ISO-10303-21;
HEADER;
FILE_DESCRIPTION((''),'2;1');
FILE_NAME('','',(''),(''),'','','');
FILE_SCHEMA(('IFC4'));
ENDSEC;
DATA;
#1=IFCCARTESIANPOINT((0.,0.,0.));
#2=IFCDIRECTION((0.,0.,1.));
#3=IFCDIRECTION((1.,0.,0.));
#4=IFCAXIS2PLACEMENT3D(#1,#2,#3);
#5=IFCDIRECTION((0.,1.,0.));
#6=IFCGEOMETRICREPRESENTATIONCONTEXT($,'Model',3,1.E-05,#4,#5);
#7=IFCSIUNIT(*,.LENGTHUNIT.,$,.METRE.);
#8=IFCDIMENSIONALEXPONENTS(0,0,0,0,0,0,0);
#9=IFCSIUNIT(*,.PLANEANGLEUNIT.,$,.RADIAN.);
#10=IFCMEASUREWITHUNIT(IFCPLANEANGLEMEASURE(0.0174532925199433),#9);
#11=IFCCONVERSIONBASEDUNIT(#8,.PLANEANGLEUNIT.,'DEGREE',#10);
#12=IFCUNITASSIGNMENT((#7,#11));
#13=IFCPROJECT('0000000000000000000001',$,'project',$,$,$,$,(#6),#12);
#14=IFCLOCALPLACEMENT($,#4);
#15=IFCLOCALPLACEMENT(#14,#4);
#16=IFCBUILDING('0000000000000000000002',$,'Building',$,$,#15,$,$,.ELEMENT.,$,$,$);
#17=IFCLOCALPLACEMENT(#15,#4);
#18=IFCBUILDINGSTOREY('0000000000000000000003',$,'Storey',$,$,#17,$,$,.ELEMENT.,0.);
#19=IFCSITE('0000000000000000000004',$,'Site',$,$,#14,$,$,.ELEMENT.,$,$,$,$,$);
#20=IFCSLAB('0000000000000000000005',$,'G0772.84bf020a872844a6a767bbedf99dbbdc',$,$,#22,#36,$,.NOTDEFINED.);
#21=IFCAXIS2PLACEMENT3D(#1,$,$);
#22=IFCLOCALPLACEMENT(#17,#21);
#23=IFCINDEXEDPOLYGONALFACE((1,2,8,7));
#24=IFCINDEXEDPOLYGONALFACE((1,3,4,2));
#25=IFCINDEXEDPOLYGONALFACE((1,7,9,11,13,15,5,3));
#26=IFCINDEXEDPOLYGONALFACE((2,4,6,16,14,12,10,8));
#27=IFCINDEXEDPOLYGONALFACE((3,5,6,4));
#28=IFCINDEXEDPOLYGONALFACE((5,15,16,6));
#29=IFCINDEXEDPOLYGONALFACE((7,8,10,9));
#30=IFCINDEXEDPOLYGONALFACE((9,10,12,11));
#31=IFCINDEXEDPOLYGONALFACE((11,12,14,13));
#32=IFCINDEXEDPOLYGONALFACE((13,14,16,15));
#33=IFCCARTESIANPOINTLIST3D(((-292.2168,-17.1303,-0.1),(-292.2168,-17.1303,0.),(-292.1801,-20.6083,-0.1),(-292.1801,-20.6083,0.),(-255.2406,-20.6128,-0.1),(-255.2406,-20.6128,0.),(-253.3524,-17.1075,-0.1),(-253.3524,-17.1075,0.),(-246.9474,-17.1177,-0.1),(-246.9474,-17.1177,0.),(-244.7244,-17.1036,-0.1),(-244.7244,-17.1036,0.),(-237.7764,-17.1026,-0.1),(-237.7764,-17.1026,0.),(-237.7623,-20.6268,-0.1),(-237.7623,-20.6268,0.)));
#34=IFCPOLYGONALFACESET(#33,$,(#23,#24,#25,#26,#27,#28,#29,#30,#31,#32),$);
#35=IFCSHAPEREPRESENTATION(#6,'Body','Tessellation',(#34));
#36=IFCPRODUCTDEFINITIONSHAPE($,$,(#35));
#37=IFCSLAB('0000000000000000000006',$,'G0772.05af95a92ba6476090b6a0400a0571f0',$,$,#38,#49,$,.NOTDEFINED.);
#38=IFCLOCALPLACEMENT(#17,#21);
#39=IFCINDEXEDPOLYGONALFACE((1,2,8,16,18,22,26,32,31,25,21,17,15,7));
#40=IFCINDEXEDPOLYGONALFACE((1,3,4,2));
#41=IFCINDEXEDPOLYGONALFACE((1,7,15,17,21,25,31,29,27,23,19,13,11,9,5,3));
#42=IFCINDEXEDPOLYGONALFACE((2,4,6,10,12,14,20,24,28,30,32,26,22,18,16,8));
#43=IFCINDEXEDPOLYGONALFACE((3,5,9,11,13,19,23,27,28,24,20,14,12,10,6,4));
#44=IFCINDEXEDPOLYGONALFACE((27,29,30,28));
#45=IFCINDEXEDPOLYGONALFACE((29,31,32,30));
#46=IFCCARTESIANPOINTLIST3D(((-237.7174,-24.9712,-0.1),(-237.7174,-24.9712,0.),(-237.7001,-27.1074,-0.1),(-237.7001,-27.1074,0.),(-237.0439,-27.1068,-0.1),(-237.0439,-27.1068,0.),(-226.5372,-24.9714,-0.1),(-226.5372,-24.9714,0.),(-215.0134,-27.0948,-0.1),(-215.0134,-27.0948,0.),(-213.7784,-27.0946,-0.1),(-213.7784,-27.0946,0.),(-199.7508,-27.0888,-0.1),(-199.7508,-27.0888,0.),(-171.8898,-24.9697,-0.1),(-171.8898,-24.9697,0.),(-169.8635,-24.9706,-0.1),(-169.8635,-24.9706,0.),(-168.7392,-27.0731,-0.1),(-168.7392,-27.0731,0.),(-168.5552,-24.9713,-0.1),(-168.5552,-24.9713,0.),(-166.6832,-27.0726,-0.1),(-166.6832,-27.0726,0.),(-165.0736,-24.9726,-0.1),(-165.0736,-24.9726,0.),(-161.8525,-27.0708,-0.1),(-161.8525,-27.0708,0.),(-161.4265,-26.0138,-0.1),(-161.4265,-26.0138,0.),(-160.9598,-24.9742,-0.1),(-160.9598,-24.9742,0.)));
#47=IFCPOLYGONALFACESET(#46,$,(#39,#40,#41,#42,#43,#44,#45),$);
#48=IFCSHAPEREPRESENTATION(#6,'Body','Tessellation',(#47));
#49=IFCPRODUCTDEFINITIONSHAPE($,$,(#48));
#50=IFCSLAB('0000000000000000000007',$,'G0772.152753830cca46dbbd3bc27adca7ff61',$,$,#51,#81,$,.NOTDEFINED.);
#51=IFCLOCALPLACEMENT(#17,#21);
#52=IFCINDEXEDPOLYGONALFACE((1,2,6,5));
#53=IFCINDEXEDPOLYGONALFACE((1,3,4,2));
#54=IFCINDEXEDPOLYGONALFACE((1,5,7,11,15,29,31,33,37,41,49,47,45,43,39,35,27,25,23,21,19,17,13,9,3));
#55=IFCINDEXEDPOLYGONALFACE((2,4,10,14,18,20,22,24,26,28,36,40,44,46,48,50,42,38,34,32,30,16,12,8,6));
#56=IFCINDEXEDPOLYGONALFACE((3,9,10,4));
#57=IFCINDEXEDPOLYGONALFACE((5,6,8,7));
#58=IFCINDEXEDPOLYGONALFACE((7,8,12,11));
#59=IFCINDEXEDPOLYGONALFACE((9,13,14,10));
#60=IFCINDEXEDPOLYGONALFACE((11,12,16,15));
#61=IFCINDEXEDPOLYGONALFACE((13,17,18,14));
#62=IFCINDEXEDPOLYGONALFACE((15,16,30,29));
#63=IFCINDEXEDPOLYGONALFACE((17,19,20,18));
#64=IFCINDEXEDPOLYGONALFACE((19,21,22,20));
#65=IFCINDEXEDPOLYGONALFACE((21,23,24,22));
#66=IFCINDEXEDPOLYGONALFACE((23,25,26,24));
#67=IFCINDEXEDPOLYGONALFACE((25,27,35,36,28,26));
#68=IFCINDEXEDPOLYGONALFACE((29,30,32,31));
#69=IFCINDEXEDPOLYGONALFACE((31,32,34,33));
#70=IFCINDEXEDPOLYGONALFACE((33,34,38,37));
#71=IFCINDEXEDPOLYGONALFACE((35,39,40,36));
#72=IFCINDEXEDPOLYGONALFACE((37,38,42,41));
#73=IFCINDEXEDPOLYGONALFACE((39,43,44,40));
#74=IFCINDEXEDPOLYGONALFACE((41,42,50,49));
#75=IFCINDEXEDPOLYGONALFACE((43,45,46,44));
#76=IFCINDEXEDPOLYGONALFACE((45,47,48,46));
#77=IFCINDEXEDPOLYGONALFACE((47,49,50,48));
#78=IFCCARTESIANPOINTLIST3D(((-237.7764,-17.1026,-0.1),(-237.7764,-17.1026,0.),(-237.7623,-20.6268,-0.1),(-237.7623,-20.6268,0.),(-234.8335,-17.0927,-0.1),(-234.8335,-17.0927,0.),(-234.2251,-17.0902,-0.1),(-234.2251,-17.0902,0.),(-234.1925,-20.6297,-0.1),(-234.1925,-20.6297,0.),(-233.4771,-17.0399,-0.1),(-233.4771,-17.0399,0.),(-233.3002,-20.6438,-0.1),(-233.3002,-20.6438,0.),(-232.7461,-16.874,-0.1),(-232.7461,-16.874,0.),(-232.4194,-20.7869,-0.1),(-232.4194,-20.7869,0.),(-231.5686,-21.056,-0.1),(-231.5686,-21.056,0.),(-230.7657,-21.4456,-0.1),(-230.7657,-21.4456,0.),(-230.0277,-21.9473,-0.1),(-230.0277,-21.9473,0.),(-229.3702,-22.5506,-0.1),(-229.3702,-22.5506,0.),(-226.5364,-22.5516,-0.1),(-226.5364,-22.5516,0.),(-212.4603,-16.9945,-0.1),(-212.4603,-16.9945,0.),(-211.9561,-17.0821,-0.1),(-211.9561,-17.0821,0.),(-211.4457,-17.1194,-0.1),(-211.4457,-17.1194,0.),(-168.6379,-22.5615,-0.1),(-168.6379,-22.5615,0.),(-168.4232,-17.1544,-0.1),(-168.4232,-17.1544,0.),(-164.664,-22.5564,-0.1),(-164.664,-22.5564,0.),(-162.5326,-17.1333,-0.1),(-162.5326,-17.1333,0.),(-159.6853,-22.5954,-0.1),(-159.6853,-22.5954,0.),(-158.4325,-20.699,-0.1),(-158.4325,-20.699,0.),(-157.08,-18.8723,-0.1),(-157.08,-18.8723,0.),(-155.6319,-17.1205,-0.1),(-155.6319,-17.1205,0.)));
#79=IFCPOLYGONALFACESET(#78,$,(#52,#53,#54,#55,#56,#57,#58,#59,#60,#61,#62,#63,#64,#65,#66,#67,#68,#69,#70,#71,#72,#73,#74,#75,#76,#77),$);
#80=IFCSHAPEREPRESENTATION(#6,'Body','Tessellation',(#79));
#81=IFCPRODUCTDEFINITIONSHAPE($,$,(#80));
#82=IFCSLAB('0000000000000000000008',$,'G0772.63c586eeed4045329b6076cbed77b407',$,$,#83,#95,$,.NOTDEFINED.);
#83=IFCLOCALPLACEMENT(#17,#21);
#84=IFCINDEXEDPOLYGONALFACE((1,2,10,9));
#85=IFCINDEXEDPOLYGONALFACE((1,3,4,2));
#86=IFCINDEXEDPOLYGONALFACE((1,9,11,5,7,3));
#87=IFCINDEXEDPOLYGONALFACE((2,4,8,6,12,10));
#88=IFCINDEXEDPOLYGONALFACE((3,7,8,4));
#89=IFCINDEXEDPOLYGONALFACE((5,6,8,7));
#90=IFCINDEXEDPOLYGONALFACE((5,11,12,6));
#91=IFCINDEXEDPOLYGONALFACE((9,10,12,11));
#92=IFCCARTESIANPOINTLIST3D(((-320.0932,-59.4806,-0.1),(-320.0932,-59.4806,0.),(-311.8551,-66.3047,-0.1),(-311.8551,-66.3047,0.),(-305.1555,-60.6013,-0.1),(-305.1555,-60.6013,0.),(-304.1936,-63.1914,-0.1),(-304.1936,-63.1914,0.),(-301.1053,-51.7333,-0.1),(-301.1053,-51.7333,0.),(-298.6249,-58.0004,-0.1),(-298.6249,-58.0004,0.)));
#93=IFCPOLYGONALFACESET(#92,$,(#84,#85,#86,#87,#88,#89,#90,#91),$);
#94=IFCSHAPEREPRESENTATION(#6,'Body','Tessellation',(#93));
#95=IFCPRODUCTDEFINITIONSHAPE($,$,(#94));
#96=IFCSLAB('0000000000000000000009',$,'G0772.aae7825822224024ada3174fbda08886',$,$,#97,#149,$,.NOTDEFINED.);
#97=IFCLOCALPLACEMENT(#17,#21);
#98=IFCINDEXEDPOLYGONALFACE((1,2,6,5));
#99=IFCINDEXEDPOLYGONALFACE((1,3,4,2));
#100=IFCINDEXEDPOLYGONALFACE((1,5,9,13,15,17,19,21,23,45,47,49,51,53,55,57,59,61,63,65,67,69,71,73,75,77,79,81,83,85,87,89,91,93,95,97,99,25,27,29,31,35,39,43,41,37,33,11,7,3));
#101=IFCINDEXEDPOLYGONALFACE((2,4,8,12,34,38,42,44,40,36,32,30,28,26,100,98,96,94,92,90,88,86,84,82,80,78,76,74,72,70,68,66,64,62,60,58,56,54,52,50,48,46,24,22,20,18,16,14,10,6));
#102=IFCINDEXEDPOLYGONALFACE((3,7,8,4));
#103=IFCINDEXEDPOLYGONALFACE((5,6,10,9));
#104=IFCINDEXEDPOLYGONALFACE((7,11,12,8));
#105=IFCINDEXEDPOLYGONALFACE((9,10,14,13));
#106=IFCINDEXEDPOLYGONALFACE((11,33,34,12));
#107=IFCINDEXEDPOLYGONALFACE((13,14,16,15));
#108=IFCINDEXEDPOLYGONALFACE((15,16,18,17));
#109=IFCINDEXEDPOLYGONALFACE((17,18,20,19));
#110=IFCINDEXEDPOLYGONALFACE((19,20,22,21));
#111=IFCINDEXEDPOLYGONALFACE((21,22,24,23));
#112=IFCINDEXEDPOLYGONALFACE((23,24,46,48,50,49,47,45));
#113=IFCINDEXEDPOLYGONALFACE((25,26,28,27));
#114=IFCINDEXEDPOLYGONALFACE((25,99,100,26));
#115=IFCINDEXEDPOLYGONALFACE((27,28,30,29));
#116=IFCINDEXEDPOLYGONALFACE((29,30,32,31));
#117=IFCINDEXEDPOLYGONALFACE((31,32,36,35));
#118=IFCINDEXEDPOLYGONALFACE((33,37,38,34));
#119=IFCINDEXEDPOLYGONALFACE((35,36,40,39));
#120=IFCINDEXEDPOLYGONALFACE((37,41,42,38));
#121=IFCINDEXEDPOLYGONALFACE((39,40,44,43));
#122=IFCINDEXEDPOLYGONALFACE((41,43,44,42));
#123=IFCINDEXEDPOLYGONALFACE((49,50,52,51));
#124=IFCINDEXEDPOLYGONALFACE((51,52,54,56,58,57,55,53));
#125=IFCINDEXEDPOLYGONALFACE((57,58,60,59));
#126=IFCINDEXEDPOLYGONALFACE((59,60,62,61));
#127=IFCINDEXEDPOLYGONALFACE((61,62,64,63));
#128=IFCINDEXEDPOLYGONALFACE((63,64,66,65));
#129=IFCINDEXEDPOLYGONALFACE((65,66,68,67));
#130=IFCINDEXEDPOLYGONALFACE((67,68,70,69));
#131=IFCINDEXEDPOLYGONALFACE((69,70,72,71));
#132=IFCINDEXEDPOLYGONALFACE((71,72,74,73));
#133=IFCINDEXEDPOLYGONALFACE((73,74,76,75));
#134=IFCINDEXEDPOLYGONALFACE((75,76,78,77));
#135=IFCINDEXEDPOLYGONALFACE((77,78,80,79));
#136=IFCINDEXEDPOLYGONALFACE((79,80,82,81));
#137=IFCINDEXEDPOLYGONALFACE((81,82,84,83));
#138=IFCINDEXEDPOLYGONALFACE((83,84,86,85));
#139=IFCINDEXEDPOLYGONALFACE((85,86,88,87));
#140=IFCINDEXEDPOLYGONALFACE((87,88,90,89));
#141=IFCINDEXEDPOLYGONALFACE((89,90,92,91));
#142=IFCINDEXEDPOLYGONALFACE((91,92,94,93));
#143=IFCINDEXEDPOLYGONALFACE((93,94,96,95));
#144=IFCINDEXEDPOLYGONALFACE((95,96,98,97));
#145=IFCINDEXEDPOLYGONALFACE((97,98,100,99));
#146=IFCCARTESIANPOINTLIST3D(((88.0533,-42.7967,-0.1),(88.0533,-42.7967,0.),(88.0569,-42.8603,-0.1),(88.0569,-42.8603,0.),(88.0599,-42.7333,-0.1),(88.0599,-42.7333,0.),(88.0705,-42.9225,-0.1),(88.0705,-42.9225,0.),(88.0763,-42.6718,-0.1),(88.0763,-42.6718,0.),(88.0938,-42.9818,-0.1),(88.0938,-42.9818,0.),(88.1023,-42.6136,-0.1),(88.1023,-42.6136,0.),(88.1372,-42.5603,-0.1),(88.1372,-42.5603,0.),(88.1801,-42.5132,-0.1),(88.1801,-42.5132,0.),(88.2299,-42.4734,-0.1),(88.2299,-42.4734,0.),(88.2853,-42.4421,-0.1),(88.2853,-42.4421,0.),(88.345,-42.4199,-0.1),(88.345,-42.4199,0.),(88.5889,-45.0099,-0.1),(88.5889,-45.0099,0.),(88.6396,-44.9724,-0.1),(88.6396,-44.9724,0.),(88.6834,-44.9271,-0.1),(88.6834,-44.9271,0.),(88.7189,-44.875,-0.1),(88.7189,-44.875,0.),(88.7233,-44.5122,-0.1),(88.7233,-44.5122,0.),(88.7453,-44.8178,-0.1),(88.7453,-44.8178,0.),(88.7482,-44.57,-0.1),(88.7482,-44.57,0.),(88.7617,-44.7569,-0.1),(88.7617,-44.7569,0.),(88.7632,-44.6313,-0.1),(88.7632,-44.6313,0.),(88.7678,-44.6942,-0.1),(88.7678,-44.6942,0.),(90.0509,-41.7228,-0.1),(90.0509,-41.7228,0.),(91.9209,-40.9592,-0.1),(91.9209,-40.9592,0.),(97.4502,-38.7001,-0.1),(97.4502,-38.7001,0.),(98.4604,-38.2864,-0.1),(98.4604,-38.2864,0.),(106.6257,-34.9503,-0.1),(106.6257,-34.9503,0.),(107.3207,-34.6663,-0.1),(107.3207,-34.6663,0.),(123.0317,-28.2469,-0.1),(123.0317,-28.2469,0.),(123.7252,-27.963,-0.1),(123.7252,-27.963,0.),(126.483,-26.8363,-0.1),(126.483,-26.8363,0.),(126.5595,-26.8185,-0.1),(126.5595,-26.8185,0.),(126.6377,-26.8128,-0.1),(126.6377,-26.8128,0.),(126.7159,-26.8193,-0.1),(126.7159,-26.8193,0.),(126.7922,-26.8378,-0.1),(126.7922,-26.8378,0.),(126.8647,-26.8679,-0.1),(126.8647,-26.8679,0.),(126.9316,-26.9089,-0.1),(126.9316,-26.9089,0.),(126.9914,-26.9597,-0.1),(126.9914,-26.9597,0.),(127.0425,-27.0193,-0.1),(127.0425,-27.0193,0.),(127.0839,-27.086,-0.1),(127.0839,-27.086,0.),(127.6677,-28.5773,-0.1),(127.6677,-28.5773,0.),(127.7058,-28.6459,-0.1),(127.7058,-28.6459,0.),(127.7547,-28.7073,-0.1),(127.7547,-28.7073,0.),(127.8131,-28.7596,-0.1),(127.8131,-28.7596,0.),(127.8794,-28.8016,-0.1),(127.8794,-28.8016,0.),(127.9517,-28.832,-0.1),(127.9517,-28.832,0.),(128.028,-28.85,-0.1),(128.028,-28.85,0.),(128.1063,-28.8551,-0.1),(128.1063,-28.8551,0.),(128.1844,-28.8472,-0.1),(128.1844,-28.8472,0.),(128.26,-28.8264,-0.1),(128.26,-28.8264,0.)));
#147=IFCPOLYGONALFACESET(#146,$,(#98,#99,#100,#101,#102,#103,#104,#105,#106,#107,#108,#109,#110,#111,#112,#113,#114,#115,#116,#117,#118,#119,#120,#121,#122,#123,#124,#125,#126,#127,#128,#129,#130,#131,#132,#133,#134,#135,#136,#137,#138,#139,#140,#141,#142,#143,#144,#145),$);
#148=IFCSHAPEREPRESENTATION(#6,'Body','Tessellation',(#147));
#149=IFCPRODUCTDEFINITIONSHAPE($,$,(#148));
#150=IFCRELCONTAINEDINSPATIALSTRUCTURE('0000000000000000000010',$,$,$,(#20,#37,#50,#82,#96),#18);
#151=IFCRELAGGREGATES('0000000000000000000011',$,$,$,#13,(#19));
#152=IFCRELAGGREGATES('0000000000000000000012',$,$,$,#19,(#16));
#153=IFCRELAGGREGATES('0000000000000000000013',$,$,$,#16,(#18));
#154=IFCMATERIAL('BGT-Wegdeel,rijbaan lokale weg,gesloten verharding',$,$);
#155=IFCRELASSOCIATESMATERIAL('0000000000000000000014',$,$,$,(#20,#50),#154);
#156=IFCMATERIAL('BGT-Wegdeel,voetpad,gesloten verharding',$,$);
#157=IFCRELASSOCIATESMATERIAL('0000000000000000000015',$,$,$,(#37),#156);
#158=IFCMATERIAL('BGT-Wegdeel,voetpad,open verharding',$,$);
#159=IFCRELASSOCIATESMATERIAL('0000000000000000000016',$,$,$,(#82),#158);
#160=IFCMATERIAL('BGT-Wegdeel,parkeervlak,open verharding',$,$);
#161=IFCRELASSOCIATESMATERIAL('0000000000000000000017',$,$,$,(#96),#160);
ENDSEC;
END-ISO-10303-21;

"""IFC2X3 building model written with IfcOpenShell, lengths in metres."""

from ifc_helpers import new_model, entity, si_unit, converted_unit, direction, frame, origin_with_axes, place, context, project, spatial, polyline, outline, extrude, material, element, save


model = new_model("IFC2X3")

# Units and contexts
model_context = context("Model", 3, precision=1e-05, world=origin_with_axes(), true_north=direction((0.0, 1.0, 0.0)))
ifc_project = project(units=[si_unit("LENGTHUNIT", "METRE"), converted_unit("PLANEANGLEUNIT", "DEGREE", entity("IfcPlaneAngleMeasure", 0.0174532925199433), si_unit("PLANEANGLEUNIT", "RADIAN"), dimensions=[0, 0, 0, 0, 0, 0, 0])], contexts=[model_context])

# Site, building, storey
site_placement = place(None, origin_with_axes())
site = spatial("IfcSite", under=ifc_project, at=site_placement, Name="Site", CompositionType="ELEMENT")
building_placement = place(site_placement, origin_with_axes())
building = spatial("IfcBuilding", under=site, at=building_placement, Name="Building", CompositionType="ELEMENT")
storey_placement = place(building_placement, origin_with_axes())
storey = spatial("IfcBuildingStorey", under=building, at=storey_placement, Name="Storey", CompositionType="ELEMENT", Elevation=0.0)

# Slabs
ifc_material_1 = material(Name="BGT-Wegdeel,parkeervlak,open verharding")
ifc_material_2 = material(Name="BGT-Wegdeel,voetpad,open verharding")
ifc_material_3 = material(Name="BGT-Wegdeel,voetpad,gesloten verharding")
ifc_material_4 = material(Name="BGT-Wegdeel,rijbaan lokale weg,gesloten verharding")
slab_1_placement = place(storey_placement, frame((0.0, 0.0, -0.1), z_axis=(0.0, 0.0, 1.0), x_axis=(1.0, 0.0, 0.0)))
element("IfcSlab", 1, at=slab_1_placement, inside=storey, material=ifc_material_4, Name="G0772.84bf020a872844a6a767bbedf99dbbdc", PredefinedType="NOTDEFINED", context=model_context, shape_type="SweptSolid", body=[
    extrude(outline(polyline([(-253.3524, -17.1075), (-246.9474, -17.1177), (-244.7244, -17.1036), (-237.7764, -17.1026), (-237.7623, -20.6268), (-255.2406, -20.6128), (-292.1801, -20.6083), (-292.2168, -17.1303), (-253.3524, -17.1075)])), origin_with_axes(), (0.0, 0.0, 1.0), 0.1),
])
slab_2_placement = place(storey_placement, frame((0.0, 0.0, -0.1), z_axis=(0.0, 0.0, 1.0), x_axis=(1.0, 0.0, 0.0)))
element("IfcSlab", 2, at=slab_2_placement, inside=storey, material=ifc_material_3, Name="G0772.05af95a92ba6476090b6a0400a0571f0", PredefinedType="NOTDEFINED", context=model_context, shape_type="SweptSolid", body=[
    extrude(outline(polyline([(-171.8898, -24.9697), (-169.8635, -24.9706), (-168.5552, -24.9713), (-165.0736, -24.9726), (-160.9598, -24.9742), (-161.4265, -26.0138), (-161.8525, -27.0708), (-166.6832, -27.0726), (-168.7392, -27.0731), (-199.7508, -27.0888), (-213.7784, -27.0946), (-215.0134, -27.0948), (-237.0439, -27.1068), (-237.7001, -27.1074), (-237.7174, -24.9712), (-226.5372, -24.9714), (-171.8898, -24.9697)])), origin_with_axes(), (0.0, 0.0, 1.0), 0.1),
])
slab_3_placement = place(storey_placement, frame((0.0, 0.0, -0.1), z_axis=(0.0, 0.0, 1.0), x_axis=(1.0, 0.0, 0.0)))
element("IfcSlab", 3, at=slab_3_placement, inside=storey, material=ifc_material_4, Name="G0772.152753830cca46dbbd3bc27adca7ff61", PredefinedType="NOTDEFINED", context=model_context, shape_type="SweptSolid", body=[
    extrude(outline(polyline([(-168.4232, -17.1544), (-162.5326, -17.1333), (-155.6319, -17.1205), (-157.08, -18.8723), (-158.4325, -20.699), (-159.6853, -22.5954), (-164.664, -22.5564), (-168.6379, -22.5615), (-226.5364, -22.5516), (-229.3702, -22.5506), (-230.0277, -21.9473), (-230.7657, -21.4456), (-231.5686, -21.056), (-232.4194, -20.7869), (-233.3002, -20.6438), (-234.1925, -20.6297), (-237.7623, -20.6268), (-237.7764, -17.1026), (-234.8335, -17.0927), (-234.2251, -17.0902), (-233.4771, -17.0399), (-232.7461, -16.874), (-212.4603, -16.9945), (-211.9561, -17.0821), (-211.4457, -17.1194), (-168.4232, -17.1544)])), origin_with_axes(), (0.0, 0.0, 1.0), 0.1),
])
slab_4_placement = place(storey_placement, frame((0.0, 0.0, -0.1), z_axis=(0.0, 0.0, 1.0), x_axis=(1.0, 0.0, 0.0)))
element("IfcSlab", 4, at=slab_4_placement, inside=storey, material=ifc_material_2, Name="G0772.63c586eeed4045329b6076cbed77b407", PredefinedType="NOTDEFINED", context=model_context, shape_type="SweptSolid", body=[
    extrude(outline(polyline([(-301.1053, -51.7333), (-298.6249, -58.0004), (-305.1555, -60.6013), (-304.1936, -63.1914), (-311.8551, -66.3047), (-320.0932, -59.4806), (-301.1053, -51.7333)])), origin_with_axes(), (0.0, 0.0, 1.0), 0.1),
])
slab_5_placement = place(storey_placement, frame((0.0, 0.0, -0.1), z_axis=(0.0, 0.0, 1.0), x_axis=(1.0, 0.0, 0.0)))
element("IfcSlab", 5, at=slab_5_placement, inside=storey, material=ifc_material_1, Name="G0772.aae7825822224024ada3174fbda08886", PredefinedType="NOTDEFINED", context=model_context, shape_type="SweptSolid", body=[
    extrude(outline(polyline([(123.0317, -28.2469), (123.7252, -27.963), (126.483, -26.8363), (126.5595, -26.8185), (126.6377, -26.8128), (126.7159, -26.8193), (126.7922, -26.8378), (126.8647, -26.8679), (126.9316, -26.9089), (126.9914, -26.9597), (127.0425, -27.0193), (127.0839, -27.086), (127.6677, -28.5773), (127.7058, -28.6459), (127.7547, -28.7073), (127.8131, -28.7596), (127.8794, -28.8016), (127.9517, -28.832), (128.028, -28.85), (128.1063, -28.8551), (128.1844, -28.8472), (128.26, -28.8264), (88.5889, -45.0099), (88.6396, -44.9724), (88.6834, -44.9271), (88.7189, -44.875), (88.7453, -44.8178), (88.7617, -44.7569), (88.7678, -44.6942), (88.7632, -44.6313), (88.7482, -44.57), (88.7233, -44.5122), (88.0938, -42.9818), (88.0705, -42.9225), (88.0569, -42.8603), (88.0533, -42.7967), (88.0599, -42.7333), (88.0763, -42.6718), (88.1023, -42.6136), (88.1372, -42.5603), (88.1801, -42.5132), (88.2299, -42.4734), (88.2853, -42.4421), (88.345, -42.4199), (90.0509, -41.7228), (91.9209, -40.9592), (97.4502, -38.7001), (98.4604, -38.2864), (106.6257, -34.9503), (107.3207, -34.6663), (123.0317, -28.2469)])), origin_with_axes(), (0.0, 0.0, 1.0), 0.1),
])

save(model, "model.ifc")
